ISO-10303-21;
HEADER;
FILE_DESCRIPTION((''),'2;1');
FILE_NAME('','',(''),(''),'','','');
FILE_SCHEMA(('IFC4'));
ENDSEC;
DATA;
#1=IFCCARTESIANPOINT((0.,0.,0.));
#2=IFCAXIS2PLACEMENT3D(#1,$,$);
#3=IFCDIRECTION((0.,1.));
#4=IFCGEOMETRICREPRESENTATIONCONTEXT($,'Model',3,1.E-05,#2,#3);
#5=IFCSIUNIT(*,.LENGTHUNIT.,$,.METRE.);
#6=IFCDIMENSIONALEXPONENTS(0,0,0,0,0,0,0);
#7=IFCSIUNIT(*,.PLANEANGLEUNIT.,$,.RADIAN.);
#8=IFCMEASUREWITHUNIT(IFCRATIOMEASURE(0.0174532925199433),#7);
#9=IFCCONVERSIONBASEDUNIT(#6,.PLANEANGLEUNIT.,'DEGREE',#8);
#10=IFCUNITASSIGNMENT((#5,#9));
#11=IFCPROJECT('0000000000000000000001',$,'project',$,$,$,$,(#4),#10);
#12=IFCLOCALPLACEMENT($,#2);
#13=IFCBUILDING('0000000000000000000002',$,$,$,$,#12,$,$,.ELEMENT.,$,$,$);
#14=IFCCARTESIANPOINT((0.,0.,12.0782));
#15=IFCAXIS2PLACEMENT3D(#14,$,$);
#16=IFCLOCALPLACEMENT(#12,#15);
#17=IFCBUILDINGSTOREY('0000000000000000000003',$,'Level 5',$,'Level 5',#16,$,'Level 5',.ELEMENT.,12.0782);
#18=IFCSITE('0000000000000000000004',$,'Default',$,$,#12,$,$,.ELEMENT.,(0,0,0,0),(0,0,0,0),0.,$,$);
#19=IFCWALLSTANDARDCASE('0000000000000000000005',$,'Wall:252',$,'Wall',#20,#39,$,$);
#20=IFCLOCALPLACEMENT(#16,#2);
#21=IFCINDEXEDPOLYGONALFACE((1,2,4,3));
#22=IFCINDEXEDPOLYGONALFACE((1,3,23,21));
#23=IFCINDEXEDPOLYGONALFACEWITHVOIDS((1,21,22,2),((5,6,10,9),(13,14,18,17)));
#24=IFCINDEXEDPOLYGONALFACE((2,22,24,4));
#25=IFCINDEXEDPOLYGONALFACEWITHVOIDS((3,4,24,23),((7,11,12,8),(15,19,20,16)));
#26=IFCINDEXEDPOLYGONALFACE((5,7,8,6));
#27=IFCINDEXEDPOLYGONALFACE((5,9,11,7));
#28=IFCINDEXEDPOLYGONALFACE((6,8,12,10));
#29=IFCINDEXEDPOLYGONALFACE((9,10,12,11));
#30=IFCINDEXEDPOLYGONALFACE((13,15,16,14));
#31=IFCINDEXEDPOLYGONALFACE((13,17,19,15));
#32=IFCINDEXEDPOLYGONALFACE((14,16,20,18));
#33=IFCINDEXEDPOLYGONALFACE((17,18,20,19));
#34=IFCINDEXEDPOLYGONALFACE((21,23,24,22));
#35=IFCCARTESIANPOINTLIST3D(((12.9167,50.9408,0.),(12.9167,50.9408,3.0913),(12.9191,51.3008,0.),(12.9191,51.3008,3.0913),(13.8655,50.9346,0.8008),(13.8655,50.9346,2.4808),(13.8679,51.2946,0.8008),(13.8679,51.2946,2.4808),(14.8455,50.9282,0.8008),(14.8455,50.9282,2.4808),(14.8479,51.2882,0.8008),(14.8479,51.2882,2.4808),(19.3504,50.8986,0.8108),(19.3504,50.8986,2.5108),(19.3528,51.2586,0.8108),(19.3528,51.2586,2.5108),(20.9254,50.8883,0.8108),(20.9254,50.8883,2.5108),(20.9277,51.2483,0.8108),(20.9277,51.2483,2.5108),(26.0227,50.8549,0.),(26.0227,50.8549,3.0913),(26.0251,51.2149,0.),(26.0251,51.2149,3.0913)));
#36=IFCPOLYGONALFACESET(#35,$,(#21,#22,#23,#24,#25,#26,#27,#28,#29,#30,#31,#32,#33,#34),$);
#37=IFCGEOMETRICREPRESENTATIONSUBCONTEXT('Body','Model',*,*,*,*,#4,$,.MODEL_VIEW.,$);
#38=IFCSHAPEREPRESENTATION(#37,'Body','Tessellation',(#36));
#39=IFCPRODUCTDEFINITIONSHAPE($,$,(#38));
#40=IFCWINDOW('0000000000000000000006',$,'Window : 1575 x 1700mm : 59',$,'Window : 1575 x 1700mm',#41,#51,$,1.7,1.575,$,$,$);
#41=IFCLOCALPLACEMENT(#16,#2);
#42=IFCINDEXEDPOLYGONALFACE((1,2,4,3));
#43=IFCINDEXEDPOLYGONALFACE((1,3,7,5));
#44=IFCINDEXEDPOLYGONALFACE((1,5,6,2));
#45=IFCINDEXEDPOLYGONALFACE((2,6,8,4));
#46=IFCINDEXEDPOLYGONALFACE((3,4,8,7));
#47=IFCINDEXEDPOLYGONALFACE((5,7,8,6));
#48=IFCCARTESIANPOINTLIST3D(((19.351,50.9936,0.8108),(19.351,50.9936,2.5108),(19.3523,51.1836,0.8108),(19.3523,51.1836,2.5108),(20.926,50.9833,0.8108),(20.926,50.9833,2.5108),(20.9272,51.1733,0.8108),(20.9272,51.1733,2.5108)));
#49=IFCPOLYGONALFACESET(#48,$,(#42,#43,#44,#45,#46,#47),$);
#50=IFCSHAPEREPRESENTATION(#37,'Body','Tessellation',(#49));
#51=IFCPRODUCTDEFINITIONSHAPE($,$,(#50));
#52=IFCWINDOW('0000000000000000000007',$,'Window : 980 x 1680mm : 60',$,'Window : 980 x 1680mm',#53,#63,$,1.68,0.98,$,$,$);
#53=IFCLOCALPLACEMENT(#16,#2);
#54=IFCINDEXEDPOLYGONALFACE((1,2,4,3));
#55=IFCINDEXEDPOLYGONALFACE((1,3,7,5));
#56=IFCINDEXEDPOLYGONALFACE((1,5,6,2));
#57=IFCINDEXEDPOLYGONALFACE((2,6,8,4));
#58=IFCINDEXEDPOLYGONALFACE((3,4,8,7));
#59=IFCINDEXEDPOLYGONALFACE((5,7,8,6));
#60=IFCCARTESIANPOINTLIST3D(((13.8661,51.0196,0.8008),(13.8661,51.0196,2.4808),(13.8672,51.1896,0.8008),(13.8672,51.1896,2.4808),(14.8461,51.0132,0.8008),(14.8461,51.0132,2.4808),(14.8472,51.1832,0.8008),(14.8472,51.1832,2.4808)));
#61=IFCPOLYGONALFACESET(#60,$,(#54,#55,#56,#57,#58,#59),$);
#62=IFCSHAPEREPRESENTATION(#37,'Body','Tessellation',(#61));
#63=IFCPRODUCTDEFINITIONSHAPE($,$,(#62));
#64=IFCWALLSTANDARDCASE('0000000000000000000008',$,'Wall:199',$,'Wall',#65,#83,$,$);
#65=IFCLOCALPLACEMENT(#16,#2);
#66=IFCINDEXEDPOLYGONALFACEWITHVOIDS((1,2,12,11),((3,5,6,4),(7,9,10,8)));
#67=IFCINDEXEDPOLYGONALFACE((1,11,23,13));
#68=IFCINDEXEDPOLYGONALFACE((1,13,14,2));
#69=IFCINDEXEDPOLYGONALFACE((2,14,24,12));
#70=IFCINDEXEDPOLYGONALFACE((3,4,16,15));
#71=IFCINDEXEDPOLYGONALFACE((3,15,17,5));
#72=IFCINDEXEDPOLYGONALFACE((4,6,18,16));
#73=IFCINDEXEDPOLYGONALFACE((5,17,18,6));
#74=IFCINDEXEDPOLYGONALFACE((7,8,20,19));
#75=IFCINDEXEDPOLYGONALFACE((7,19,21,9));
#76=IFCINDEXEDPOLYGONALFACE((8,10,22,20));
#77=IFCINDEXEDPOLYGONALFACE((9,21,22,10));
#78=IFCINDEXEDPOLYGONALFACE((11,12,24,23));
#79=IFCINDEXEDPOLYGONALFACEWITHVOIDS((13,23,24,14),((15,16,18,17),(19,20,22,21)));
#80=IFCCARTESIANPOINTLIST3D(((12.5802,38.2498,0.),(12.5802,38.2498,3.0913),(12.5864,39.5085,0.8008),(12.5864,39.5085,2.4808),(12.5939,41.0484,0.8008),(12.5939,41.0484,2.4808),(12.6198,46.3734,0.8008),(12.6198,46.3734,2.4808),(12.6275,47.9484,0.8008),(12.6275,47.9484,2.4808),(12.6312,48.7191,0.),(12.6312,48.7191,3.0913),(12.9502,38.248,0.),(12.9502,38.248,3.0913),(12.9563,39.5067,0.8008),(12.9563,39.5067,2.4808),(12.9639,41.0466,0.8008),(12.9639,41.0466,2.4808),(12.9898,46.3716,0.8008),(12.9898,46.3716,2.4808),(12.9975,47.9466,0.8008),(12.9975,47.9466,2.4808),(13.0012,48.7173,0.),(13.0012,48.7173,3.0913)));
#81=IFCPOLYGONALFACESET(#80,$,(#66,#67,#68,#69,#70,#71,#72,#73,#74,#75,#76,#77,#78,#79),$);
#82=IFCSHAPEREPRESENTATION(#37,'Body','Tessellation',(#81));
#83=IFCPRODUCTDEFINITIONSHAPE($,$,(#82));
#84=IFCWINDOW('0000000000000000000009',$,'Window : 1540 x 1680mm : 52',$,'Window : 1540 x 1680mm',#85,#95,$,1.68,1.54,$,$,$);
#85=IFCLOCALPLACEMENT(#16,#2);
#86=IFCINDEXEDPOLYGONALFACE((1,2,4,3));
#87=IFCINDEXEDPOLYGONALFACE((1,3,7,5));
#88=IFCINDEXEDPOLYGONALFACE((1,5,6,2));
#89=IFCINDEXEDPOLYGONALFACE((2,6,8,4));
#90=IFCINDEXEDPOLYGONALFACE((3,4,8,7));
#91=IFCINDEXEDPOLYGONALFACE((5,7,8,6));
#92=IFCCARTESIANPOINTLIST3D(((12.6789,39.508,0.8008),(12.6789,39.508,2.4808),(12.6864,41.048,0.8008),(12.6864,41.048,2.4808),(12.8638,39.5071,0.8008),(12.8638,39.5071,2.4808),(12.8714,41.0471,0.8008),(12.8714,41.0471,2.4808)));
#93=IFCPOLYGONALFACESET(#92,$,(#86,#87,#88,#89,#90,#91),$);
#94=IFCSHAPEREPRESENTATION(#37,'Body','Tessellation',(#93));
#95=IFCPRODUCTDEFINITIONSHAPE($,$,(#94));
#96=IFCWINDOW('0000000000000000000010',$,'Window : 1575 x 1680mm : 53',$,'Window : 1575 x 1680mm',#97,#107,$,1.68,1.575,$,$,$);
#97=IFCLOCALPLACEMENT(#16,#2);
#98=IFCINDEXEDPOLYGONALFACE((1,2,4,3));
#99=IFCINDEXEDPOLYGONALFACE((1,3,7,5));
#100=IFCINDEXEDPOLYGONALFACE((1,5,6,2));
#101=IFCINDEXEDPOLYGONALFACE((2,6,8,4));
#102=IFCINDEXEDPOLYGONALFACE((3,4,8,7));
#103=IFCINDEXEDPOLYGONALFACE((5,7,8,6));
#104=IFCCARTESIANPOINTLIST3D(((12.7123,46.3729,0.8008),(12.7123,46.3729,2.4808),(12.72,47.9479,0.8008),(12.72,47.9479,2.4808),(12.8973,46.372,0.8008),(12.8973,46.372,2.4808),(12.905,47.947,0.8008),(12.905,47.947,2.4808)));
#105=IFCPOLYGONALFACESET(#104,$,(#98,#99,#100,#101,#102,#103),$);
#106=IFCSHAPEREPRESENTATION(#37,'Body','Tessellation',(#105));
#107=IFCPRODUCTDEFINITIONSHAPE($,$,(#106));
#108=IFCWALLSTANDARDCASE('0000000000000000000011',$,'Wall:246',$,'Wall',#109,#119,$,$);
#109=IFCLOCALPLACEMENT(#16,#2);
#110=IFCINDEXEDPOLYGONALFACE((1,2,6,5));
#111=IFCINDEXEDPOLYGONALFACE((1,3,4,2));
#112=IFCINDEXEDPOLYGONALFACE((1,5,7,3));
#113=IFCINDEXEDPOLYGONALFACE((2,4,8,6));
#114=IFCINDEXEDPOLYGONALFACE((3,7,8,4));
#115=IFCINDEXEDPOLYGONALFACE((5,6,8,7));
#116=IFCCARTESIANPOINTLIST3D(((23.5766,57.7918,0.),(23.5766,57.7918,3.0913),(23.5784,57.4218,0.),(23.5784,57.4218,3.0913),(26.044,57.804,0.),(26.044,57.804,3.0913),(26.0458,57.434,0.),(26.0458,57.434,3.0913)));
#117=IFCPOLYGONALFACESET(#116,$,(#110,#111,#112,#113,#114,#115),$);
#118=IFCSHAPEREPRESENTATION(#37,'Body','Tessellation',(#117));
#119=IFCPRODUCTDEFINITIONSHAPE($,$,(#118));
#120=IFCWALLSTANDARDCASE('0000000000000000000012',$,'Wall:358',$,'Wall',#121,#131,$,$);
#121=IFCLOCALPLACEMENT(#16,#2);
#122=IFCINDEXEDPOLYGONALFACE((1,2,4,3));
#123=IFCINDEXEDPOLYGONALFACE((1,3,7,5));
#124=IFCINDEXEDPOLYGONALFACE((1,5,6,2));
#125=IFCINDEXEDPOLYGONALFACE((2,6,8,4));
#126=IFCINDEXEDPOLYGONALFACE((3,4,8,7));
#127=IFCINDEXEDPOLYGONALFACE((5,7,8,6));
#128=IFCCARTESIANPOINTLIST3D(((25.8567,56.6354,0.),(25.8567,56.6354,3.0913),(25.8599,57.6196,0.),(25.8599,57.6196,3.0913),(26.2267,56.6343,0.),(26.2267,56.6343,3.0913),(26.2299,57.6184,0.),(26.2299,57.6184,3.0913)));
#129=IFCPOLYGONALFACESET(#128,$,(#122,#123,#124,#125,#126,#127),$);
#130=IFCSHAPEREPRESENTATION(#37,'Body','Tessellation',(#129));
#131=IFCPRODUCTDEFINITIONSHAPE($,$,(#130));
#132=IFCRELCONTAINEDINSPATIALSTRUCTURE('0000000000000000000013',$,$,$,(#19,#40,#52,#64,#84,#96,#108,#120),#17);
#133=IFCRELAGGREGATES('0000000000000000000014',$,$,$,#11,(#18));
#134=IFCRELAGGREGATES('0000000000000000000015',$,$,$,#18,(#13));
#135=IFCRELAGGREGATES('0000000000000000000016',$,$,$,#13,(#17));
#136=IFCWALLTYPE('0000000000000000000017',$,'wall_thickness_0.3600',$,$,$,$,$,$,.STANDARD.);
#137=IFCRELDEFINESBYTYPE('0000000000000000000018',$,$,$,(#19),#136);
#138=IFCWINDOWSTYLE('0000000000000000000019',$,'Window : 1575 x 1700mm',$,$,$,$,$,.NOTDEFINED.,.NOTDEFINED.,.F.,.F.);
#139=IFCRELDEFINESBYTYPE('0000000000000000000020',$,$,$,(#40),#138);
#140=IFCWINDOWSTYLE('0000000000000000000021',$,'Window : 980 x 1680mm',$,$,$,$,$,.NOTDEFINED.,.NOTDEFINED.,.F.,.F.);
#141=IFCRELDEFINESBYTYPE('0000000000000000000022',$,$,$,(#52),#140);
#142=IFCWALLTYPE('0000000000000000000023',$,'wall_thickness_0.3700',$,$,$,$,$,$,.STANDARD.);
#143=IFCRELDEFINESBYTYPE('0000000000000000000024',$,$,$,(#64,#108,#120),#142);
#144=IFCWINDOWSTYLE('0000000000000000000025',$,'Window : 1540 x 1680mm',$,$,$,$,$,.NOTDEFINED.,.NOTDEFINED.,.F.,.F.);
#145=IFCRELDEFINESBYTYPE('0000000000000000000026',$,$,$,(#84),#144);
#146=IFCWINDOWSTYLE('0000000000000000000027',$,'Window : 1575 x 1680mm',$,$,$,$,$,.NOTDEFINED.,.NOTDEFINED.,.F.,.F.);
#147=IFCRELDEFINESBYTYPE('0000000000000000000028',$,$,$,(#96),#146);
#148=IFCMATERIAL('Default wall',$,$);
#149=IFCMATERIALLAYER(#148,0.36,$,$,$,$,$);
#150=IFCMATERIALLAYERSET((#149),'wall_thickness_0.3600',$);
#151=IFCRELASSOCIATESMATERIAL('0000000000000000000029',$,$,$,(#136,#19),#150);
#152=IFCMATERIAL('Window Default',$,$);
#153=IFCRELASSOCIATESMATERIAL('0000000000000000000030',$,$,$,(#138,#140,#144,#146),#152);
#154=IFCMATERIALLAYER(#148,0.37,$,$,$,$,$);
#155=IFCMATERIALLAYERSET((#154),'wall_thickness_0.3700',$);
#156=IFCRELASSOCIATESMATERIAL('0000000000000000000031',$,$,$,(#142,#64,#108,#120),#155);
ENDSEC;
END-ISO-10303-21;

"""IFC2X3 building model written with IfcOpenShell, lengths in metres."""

from ifc_helpers import new_model, entity, si_unit, converted_unit, direction, frame, frame_2d, origin, origin_2d_with_axis, place, context, subcontext, project, spatial, polyline, rectangle, outline, extrude, clip, halfspace, source, transform, mapped, material, layer, layer_set, layer_usage, type_object, type_shapes, element, fill, save


model = new_model("IFC2X3")

# Units and contexts
model_context = context("Model", 3, precision=1e-05, world=origin(), true_north=direction((0.0, 1.0)))
body_context = subcontext(model_context, "Body", "Model", "MODEL_VIEW")
ifc_project = project(units=[si_unit("LENGTHUNIT", "METRE"), converted_unit("PLANEANGLEUNIT", "DEGREE", entity("IfcRatioMeasure", 0.0174532925199433), si_unit("PLANEANGLEUNIT", "RADIAN"), dimensions=[0, 0, 0, 0, 0, 0, 0])], contexts=[model_context])

# Site, building, storey
placement_1 = place(None, origin())
site = spatial("IfcSite", under=ifc_project, at=placement_1, Name="Default", CompositionType="ELEMENT", RefLatitude=(0, 0, 0, 0), RefLongitude=(0, 0, 0, 0), RefElevation=0.0)
building = spatial("IfcBuilding", under=site, at=placement_1, CompositionType="ELEMENT")
storey_placement = place(placement_1, frame((0.0, 0.0, 12.0782)))
storey = spatial("IfcBuildingStorey", under=building, at=storey_placement, Name="Level 5", ObjectType="Level 5", LongName="Level 5", CompositionType="ELEMENT", Elevation=12.0782)

# Shared definitions
ifc_material_1 = material(Name="Default wall")

# Wall, openings, windows
ifc_layer_1 = layer(ifc_material_1, 0.36)
ifc_layer_set_1 = layer_set([ifc_layer_1], Name="wall_thickness_0.3600")
ifc_layer_usage_1 = layer_usage(ifc_layer_set_1, "AXIS2", "POSITIVE", -0.18)
wall_type_1 = type_object("IfcWallType", Name="wall_thickness_0.3600", PredefinedType="STANDARD", material=ifc_layer_set_1)
wall_1_placement = place(storey_placement, frame((12.9179, 51.1208, 0.0), z_axis=(0.0, 0.0, 1.0), x_axis=(0.999978, -0.006559, 0.0)))
wall_1 = element("IfcWallStandardCase", 1, at=wall_1_placement, inside=storey, type_object=wall_type_1, material=ifc_layer_usage_1, Name="Wall:252", ObjectType="Wall", context=body_context, shape_type="Clipping", body=[
    clip(extrude(outline(polyline([(13.1062, -0.18), (13.1062, 0.18), (0.0, 0.18), (0.0, -0.18), (13.1062, -0.18)])), origin(), (0.0, 0.0, 1.0), 3.0913), halfspace(frame((-25.7144, 6.5177, 9.0175), z_axis=(-0.001319, -0.391127, 0.920336), x_axis=(0.999998, -0.001587, 0.000759)), False)),
])
opening_1_placement = place(wall_1_placement, frame((6.4338, -0.18, 0.8108)))
opening_1 = element("IfcOpeningElement", 2, at=opening_1_placement, cuts=wall_1, ObjectType="Opening", context=body_context, shape_type="SweptSolid", body=[
    extrude(rectangle(XDim=1.575, YDim=1.7, at=frame_2d((0.85, 0.7875), x_axis=(0.0, 1.0))), frame((0.0, 0.0, 0.0), z_axis=(0.0, 1.0, 0.0), x_axis=(0.0, 0.0, 1.0)), (0.0, 0.0, 1.0), 0.36),
])
opening_2_placement = place(wall_1_placement, frame((0.9488, -0.18, 0.8008)))
opening_2 = element("IfcOpeningElement", 3, at=opening_2_placement, cuts=wall_1, ObjectType="Opening", context=body_context, shape_type="SweptSolid", body=[
    extrude(rectangle(XDim=0.98, YDim=1.68, at=frame_2d((0.84, 0.49), x_axis=(0.0, 1.0))), frame((0.0, 0.0, 0.0), z_axis=(0.0, 1.0, 0.0), x_axis=(0.0, 0.0, 1.0)), (0.0, 0.0, 1.0), 0.36),
])
ifc_material_2 = material(Name="Window Default")
window_style_1 = type_object("IfcWindowStyle", Name="Window : 1575 x 1700mm", ConstructionType="NOTDEFINED", OperationType="NOTDEFINED", ParameterTakesPrecedence=False, Sizeable=False, material=ifc_material_2)
shared_shape_1 = source(origin(), body_context, "Body", "SweptSolid", [
    extrude(rectangle(XDim=0.19, YDim=1.575, at=origin_2d_with_axis()), frame((0.7875, 0.19, 0.0), z_axis=(0.0, 0.0, 1.0), x_axis=(0.0, 1.0, 0.0)), (0.0, 0.0, 1.0), 1.7),
])
type_shapes(window_style_1, [shared_shape_1])
window_1_placement = place(opening_1_placement, origin())
window_1 = element("IfcWindow", 4, at=window_1_placement, inside=storey, type_object=window_style_1, Name="Window : 1575 x 1700mm : 59", ObjectType="Window : 1575 x 1700mm", OverallHeight=1.7, OverallWidth=1.575, context=body_context, shape_type="MappedRepresentation", body=[
    mapped(shared_shape_1, transform((0.0, 0.0, 0.0), scale=1.0)),
])
fill(opening_1, window_1)
window_style_2 = type_object("IfcWindowStyle", Name="Window : 980 x 1680mm", ConstructionType="NOTDEFINED", OperationType="NOTDEFINED", ParameterTakesPrecedence=False, Sizeable=False, material=ifc_material_2)
shared_shape_2 = source(origin(), body_context, "Body", "SweptSolid", [
    extrude(rectangle(XDim=0.17, YDim=0.98, at=origin_2d_with_axis()), frame((0.49, 0.17, 0.0), z_axis=(0.0, 0.0, 1.0), x_axis=(0.0, 1.0, 0.0)), (0.0, 0.0, 1.0), 1.68),
])
type_shapes(window_style_2, [shared_shape_2])
window_2_placement = place(opening_2_placement, origin())
window_2 = element("IfcWindow", 5, at=window_2_placement, inside=storey, type_object=window_style_2, Name="Window : 980 x 1680mm : 60", ObjectType="Window : 980 x 1680mm", OverallHeight=1.68, OverallWidth=0.98, context=body_context, shape_type="MappedRepresentation", body=[
    mapped(shared_shape_2, transform((0.0, 0.0, 0.0), scale=1.0)),
])
fill(opening_2, window_2)

# Wall, openings, windows
ifc_layer_2 = layer(ifc_material_1, 0.37)
ifc_layer_set_2 = layer_set([ifc_layer_2], Name="wall_thickness_0.3700")
ifc_layer_usage_2 = layer_usage(ifc_layer_set_2, "AXIS2", "POSITIVE", -0.185)
wall_type_2 = type_object("IfcWallType", Name="wall_thickness_0.3700", PredefinedType="STANDARD", material=ifc_layer_set_2)
wall_2_placement = place(storey_placement, frame((12.8162, 48.7182, 0.0), z_axis=(0.0, 0.0, 1.0), x_axis=(-0.004871, -0.999988, 0.0)))
wall_2 = element("IfcWallStandardCase", 6, at=wall_2_placement, inside=storey, type_object=wall_type_2, material=ifc_layer_usage_2, Name="Wall:199", ObjectType="Wall", context=body_context, shape_type="Clipping", body=[
    clip(extrude(outline(polyline([(10.4695, -0.185), (10.4695, 0.185), (0.0, 0.185), (0.0, -0.185), (10.4695, -0.185)])), origin(), (0.0, 0.0, 1.0), 3.0913), halfspace(frame((-28.5212, 1.127, 5.8218), z_axis=(0.000002, 0.390505, 0.920601), x_axis=(0.000493, -0.920601, 0.390505)), False)),
])
opening_3_placement = place(wall_2_placement, frame((7.6708, -0.185, 0.8008)))
opening_3 = element("IfcOpeningElement", 7, at=opening_3_placement, cuts=wall_2, ObjectType="Opening", context=body_context, shape_type="SweptSolid", body=[
    extrude(rectangle(XDim=1.54, YDim=1.68, at=frame_2d((0.84, 0.77), x_axis=(0.0, 1.0))), frame((0.0, 0.0, 0.0), z_axis=(0.0, 1.0, 0.0), x_axis=(0.0, 0.0, 1.0)), (0.0, 0.0, 1.0), 0.37),
])
opening_4_placement = place(wall_2_placement, frame((0.7708, -0.185, 0.8008)))
opening_4 = element("IfcOpeningElement", 8, at=opening_4_placement, cuts=wall_2, ObjectType="Opening", context=body_context, shape_type="SweptSolid", body=[
    extrude(rectangle(XDim=1.575, YDim=1.68, at=frame_2d((0.84, 0.7875), x_axis=(0.0, 1.0))), frame((0.0, 0.0, 0.0), z_axis=(0.0, 1.0, 0.0), x_axis=(0.0, 0.0, 1.0)), (0.0, 0.0, 1.0), 0.37),
])
window_style_3 = type_object("IfcWindowStyle", Name="Window : 1540 x 1680mm", ConstructionType="NOTDEFINED", OperationType="NOTDEFINED", ParameterTakesPrecedence=False, Sizeable=False, material=ifc_material_2)
shared_shape_3 = source(origin(), body_context, "Body", "SweptSolid", [
    extrude(rectangle(XDim=0.185, YDim=1.54, at=origin_2d_with_axis()), frame((0.77, 0.185, 0.0), z_axis=(0.0, 0.0, 1.0), x_axis=(0.0, 1.0, 0.0)), (0.0, 0.0, 1.0), 1.68),
])
type_shapes(window_style_3, [shared_shape_3])
window_3_placement = place(opening_3_placement, origin())
window_3 = element("IfcWindow", 9, at=window_3_placement, inside=storey, type_object=window_style_3, Name="Window : 1540 x 1680mm : 52", ObjectType="Window : 1540 x 1680mm", OverallHeight=1.68, OverallWidth=1.54, context=body_context, shape_type="MappedRepresentation", body=[
    mapped(shared_shape_3, transform((0.0, 0.0, 0.0), scale=1.0)),
])
fill(opening_3, window_3)
window_style_4 = type_object("IfcWindowStyle", Name="Window : 1575 x 1680mm", ConstructionType="NOTDEFINED", OperationType="NOTDEFINED", ParameterTakesPrecedence=False, Sizeable=False, material=ifc_material_2)
shared_shape_4 = source(origin(), body_context, "Body", "SweptSolid", [
    extrude(rectangle(XDim=0.185, YDim=1.575, at=origin_2d_with_axis()), frame((0.7875, 0.185, 0.0), z_axis=(0.0, 0.0, 1.0), x_axis=(0.0, 1.0, 0.0)), (0.0, 0.0, 1.0), 1.68),
])
type_shapes(window_style_4, [shared_shape_4])
window_4_placement = place(opening_4_placement, origin())
window_4 = element("IfcWindow", 10, at=window_4_placement, inside=storey, type_object=window_style_4, Name="Window : 1575 x 1680mm : 53", ObjectType="Window : 1575 x 1680mm", OverallHeight=1.68, OverallWidth=1.575, context=body_context, shape_type="MappedRepresentation", body=[
    mapped(shared_shape_4, transform((0.0, 0.0, 0.0), scale=1.0)),
])
fill(opening_4, window_4)

# Walls
wall_3_placement = place(storey_placement, frame((23.5775, 57.6068, 0.0), z_axis=(0.0, 0.0, 1.0), x_axis=(0.999988, 0.004929, 0.0)))
element("IfcWallStandardCase", 11, at=wall_3_placement, inside=storey, type_object=wall_type_2, material=ifc_layer_usage_2, Name="Wall:246", ObjectType="Wall", context=body_context, shape_type="SweptSolid", body=[
    extrude(outline(polyline([(2.4674, -0.185), (2.4674, 0.185), (0.0, 0.185), (0.0, -0.185), (2.4674, -0.185)])), origin(), (0.0, 0.0, 1.0), 3.0913),
])
wall_4_placement = place(storey_placement, frame((26.0449, 57.619, 0.0), z_axis=(0.0, 0.0, 1.0), x_axis=(-0.00319, -0.999995, 0.0)))
element("IfcWallStandardCase", 12, at=wall_4_placement, inside=storey, type_object=wall_type_2, material=ifc_layer_usage_2, Name="Wall:358", ObjectType="Wall", context=body_context, shape_type="SweptSolid", body=[
    extrude(outline(polyline([(0.9842, -0.185), (0.9842, 0.185), (0.0, 0.185), (0.0, -0.185), (0.9842, -0.185)])), origin(), (0.0, 0.0, 1.0), 3.0913),
])

save(model, "model.ifc")
